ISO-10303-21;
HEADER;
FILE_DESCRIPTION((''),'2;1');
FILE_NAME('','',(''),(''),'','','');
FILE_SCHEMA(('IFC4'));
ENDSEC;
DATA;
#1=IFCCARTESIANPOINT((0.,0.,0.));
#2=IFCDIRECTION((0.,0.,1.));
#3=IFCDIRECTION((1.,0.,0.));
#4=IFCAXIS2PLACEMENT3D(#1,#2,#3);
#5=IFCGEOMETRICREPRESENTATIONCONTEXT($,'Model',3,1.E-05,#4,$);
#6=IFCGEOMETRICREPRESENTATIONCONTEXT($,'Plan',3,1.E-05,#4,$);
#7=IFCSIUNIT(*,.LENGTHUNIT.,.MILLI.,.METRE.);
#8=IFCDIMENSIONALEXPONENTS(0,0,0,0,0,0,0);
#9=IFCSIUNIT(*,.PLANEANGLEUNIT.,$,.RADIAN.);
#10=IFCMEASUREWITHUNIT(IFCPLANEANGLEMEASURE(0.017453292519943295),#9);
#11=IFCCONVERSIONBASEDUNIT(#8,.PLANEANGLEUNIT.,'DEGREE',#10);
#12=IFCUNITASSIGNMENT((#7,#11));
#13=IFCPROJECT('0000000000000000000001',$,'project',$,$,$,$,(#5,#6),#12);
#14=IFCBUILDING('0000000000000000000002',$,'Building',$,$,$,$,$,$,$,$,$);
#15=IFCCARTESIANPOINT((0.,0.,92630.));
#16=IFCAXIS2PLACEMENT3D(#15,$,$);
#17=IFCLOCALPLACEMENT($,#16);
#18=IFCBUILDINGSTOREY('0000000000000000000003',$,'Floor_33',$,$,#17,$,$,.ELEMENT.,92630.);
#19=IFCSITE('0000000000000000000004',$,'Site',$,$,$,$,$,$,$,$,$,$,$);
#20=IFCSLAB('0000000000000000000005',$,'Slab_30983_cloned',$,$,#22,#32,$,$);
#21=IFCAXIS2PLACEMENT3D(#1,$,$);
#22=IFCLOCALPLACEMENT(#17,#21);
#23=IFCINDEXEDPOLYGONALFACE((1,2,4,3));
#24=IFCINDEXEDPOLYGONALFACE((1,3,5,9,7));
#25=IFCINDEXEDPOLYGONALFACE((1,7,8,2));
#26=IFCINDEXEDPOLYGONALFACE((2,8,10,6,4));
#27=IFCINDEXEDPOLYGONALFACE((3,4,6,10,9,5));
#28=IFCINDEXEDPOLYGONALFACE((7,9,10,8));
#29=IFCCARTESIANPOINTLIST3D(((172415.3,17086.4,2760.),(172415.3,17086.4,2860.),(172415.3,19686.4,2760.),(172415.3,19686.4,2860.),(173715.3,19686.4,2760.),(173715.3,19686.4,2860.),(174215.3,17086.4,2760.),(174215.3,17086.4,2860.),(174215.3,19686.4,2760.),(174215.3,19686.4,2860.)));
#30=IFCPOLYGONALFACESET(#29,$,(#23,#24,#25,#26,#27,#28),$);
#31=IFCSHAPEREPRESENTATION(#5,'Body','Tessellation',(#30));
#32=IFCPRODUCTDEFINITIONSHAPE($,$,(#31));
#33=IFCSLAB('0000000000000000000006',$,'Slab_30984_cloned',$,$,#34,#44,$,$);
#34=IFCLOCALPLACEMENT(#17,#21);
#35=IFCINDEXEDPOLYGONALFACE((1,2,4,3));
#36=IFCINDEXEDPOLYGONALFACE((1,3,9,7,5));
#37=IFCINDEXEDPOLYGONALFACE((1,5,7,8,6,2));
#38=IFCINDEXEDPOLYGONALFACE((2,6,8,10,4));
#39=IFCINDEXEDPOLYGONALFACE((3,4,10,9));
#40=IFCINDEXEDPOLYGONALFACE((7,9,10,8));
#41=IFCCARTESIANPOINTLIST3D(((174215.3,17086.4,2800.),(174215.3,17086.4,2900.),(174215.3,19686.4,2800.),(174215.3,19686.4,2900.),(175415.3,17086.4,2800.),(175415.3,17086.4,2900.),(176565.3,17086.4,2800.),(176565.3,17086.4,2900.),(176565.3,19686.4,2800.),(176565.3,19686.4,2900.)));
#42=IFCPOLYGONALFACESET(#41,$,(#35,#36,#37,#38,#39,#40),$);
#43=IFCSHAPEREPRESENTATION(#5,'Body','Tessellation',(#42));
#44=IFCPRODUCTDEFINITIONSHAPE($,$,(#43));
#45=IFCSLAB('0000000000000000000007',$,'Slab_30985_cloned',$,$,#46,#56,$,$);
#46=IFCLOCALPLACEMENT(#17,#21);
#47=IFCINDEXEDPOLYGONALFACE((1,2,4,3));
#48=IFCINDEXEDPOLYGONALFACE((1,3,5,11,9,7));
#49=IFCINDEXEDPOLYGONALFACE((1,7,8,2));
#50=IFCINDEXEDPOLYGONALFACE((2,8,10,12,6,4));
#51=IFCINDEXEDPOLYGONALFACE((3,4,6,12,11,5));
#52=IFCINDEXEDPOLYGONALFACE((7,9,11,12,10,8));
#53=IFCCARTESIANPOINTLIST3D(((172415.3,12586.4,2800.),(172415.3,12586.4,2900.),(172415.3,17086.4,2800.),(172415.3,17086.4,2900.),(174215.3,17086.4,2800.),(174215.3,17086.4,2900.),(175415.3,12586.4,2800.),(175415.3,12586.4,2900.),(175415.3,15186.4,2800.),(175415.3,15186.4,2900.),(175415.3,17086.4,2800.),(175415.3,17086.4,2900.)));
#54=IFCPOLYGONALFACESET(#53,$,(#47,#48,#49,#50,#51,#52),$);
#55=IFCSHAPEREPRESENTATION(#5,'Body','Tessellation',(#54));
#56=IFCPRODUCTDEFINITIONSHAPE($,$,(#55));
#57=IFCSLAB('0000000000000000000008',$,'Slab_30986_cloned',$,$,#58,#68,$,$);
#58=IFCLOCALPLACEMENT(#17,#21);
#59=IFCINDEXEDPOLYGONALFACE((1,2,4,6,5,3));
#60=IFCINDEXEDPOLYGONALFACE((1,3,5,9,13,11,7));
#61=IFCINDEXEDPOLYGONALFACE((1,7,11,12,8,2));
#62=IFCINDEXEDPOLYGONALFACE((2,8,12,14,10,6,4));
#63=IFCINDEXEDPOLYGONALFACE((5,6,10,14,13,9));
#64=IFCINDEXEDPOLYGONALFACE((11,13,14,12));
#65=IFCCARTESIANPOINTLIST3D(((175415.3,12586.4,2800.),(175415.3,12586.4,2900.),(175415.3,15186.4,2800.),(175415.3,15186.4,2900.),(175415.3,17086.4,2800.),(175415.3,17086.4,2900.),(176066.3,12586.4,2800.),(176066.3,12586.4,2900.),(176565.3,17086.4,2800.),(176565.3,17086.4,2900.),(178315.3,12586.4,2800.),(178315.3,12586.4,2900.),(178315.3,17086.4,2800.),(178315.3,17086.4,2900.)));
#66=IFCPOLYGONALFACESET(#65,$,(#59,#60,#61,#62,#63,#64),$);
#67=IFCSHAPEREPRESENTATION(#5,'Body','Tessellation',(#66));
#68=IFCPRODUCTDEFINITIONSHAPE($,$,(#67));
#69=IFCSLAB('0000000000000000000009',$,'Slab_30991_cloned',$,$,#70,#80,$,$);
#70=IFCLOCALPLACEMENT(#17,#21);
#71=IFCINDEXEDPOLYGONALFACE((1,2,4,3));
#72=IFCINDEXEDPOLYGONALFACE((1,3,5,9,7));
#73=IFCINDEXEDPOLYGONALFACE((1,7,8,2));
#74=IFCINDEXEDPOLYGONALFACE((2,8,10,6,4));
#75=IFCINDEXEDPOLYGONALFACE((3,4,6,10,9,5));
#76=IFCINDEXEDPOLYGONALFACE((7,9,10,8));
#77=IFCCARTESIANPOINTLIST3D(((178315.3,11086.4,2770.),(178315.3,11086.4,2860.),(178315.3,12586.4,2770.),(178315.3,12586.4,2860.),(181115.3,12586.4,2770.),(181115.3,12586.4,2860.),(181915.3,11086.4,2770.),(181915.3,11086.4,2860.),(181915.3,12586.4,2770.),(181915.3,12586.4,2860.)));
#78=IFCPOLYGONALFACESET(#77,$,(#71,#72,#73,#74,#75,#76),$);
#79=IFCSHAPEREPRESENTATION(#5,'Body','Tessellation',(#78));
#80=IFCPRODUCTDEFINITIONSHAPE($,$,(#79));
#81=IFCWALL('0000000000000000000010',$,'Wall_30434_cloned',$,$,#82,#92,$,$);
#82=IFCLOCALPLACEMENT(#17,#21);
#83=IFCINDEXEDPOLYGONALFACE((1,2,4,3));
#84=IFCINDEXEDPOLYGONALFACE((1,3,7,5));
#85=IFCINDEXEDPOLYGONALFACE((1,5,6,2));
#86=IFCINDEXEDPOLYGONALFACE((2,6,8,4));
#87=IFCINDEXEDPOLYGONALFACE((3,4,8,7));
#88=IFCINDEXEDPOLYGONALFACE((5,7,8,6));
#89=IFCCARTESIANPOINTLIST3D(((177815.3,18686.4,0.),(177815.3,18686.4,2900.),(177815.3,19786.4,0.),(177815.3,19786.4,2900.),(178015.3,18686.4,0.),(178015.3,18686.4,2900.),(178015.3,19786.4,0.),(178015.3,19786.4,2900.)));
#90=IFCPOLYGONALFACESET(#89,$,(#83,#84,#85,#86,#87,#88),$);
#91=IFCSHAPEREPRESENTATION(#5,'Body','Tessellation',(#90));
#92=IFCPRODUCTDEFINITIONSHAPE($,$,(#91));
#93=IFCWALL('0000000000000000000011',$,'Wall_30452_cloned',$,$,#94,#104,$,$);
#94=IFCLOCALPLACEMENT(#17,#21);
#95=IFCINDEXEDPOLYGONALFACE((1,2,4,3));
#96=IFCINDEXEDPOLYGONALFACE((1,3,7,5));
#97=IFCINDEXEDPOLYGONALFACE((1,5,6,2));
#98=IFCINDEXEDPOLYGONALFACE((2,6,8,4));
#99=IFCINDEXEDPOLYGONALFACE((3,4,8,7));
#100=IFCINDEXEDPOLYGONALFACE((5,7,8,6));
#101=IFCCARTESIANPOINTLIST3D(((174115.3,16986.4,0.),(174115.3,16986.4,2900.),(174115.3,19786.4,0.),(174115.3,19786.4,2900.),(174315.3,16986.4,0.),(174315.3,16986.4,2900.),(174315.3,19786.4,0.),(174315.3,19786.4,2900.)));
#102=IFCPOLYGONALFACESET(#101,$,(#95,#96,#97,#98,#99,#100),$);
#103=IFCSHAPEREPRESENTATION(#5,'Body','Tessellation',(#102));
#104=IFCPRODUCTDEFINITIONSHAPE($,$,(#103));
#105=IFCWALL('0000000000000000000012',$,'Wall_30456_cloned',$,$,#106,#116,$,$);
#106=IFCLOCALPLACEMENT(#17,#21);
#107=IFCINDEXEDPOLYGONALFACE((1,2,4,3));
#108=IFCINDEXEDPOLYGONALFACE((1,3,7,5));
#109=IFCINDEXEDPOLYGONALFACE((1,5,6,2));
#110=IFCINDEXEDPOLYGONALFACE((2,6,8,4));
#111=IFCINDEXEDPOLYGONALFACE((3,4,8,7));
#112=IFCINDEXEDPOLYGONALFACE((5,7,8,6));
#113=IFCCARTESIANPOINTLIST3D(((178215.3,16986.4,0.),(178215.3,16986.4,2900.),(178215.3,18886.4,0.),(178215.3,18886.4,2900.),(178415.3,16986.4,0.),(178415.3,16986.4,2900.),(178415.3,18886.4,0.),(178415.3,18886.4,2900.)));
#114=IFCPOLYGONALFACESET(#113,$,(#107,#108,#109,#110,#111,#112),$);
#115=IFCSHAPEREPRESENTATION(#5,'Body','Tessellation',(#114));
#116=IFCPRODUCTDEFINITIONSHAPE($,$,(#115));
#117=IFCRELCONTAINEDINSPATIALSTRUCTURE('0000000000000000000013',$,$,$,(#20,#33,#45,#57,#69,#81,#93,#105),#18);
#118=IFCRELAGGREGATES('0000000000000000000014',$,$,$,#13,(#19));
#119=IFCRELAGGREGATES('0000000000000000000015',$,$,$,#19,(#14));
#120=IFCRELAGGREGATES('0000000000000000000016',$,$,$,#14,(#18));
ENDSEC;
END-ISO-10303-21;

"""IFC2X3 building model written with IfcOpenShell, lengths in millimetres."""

from ifc_helpers import new_model, entity, si_unit, converted_unit, frame, origin_with_axes, origin_2d, place, context, project, spatial, polyline, rectangle, outline, extrude, source, transform, mapped, element, save


model = new_model("IFC2X3")

# Units and contexts
model_context = context("Model", 3, precision=1e-05, world=origin_with_axes())
plan_context = context("Plan", 3, precision=1e-05, world=origin_with_axes())
ifc_project = project(units=[si_unit("LENGTHUNIT", "METRE", prefix="MILLI"), converted_unit("PLANEANGLEUNIT", "DEGREE", entity("IfcPlaneAngleMeasure", 0.017453292519943295), si_unit("PLANEANGLEUNIT", "RADIAN"), dimensions=[0, 0, 0, 0, 0, 0, 0])], contexts=[model_context, plan_context])

# Site, building, storey
site = spatial("IfcSite", under=ifc_project, Name="Site")
building = spatial("IfcBuilding", under=site, Name="Building")
storey_placement = place(None, frame((0.0, 0.0, 92630.0)))
storey = spatial("IfcBuildingStorey", under=building, at=storey_placement, Name="Floor_33", CompositionType="ELEMENT", Elevation=92630.0)

# Slabs
shared_shape_1 = source(origin_with_axes(), model_context, "Body", "SweptSolid", [
    extrude(outline(polyline([(0.0, 0.0), (2600.0, 0.0), (2600.0, 1800.0), (0.0, 1800.0), (0.0, 1300.0)])), origin_with_axes(), (0.0, 0.0, 1.0), 100.0),
])
slab_1_placement = place(storey_placement, frame((172415.3, 19686.4, 2760.0), z_axis=(0.0, 0.0, 1.0), x_axis=(0.0, -2599.99, 0.0)))
element("IfcSlab", 1, at=slab_1_placement, inside=storey, Name="Slab_30983_cloned", context=model_context, shape_type="MappedRepresentation", body=[
    mapped(shared_shape_1, transform((0.0, 0.0, 0.0), x_axis=(1.0, 0.0, 0.0), y_axis=(0.0, 1.0, 0.0), z_axis=(0.0, 0.0, 1.0), scale=1.0)),
])
shared_shape_2 = source(origin_with_axes(), model_context, "Body", "SweptSolid", [
    extrude(outline(polyline([(0.0, 0.0), (2600.0, 0.0), (2600.0, 1200.0), (2600.0, 2350.0), (0.0, 2350.0)])), origin_with_axes(), (0.0, 0.0, 1.0), 100.0),
])
slab_2_placement = place(storey_placement, frame((174215.3, 19686.4, 2800.0), z_axis=(0.0, 0.0, 1.0), x_axis=(0.0, -2599.99, 0.0)))
element("IfcSlab", 2, at=slab_2_placement, inside=storey, Name="Slab_30984_cloned", context=model_context, shape_type="MappedRepresentation", body=[
    mapped(shared_shape_2, transform((0.0, 0.0, 0.0), x_axis=(1.0, 0.0, 0.0), y_axis=(0.0, 1.0, 0.0), z_axis=(0.0, 0.0, 1.0), scale=1.0)),
])
shared_shape_3 = source(origin_with_axes(), model_context, "Body", "SweptSolid", [
    extrude(outline(polyline([(0.0, 0.0), (4500.0, 0.0), (4500.0, 3000.0), (1900.0, 3000.0), (0.0, 3000.0), (0.0, 1800.0)])), origin_with_axes(), (0.0, 0.0, 1.0), 100.0),
])
slab_3_placement = place(storey_placement, frame((172415.3, 17086.4, 2800.0), z_axis=(0.0, 0.0, 1.0), x_axis=(0.0, -4500.031, 0.0)))
element("IfcSlab", 3, at=slab_3_placement, inside=storey, Name="Slab_30985_cloned", context=model_context, shape_type="MappedRepresentation", body=[
    mapped(shared_shape_3, transform((0.0, 0.0, 0.0), x_axis=(1.0, 0.0, 0.0), y_axis=(0.0, 1.0, 0.0), z_axis=(0.0, 0.0, 1.0), scale=1.0)),
])
shared_shape_4 = source(origin_with_axes(), model_context, "Body", "SweptSolid", [
    extrude(outline(polyline([(0.0, 0.0), (1900.0, 0.0), (4500.0, 0.0), (4500.0, 651.0), (4500.0, 2900.0), (0.0, 2900.0), (0.0, 1150.0)])), origin_with_axes(), (0.0, 0.0, 1.0), 100.0),
])
slab_4_placement = place(storey_placement, frame((175415.3, 17086.4, 2800.0), z_axis=(0.0, 0.0, 1.0), x_axis=(-0.006, -1900.025, 0.0)))
element("IfcSlab", 4, at=slab_4_placement, inside=storey, Name="Slab_30986_cloned", context=model_context, shape_type="MappedRepresentation", body=[
    mapped(shared_shape_4, transform((0.0, 0.0, 0.0), x_axis=(1.0, 0.0, 0.0), y_axis=(0.0, 1.0, 0.0), z_axis=(0.0, 0.0, 1.0), scale=1.0)),
])
shared_shape_5 = source(origin_with_axes(), model_context, "Body", "SweptSolid", [
    extrude(outline(polyline([(0.0, 0.0), (1500.0, 0.0), (1500.0, 3600.0), (0.0, 3600.0), (0.0, 2800.0)])), origin_with_axes(), (0.0, 0.0, 1.0), 90.0),
])
slab_5_placement = place(storey_placement, frame((178315.3, 12586.4, 2770.0), z_axis=(0.0, 0.0, 1.0), x_axis=(0.0, -1500.0, 0.0)))
element("IfcSlab", 5, at=slab_5_placement, inside=storey, Name="Slab_30991_cloned", context=model_context, shape_type="MappedRepresentation", body=[
    mapped(shared_shape_5, transform((0.0, 0.0, 0.0), x_axis=(1.0, 0.0, 0.0), y_axis=(0.0, 1.0, 0.0), z_axis=(0.0, 0.0, 1.0), scale=1.0)),
])

# Walls
shared_shape_6 = source(origin_with_axes(), model_context, "Body", "SweptSolid", [
    extrude(rectangle(XDim=1100.0, YDim=200.0, at=origin_2d()), origin_with_axes(), (0.0, 0.0, 1.0), 2900.0),
])
wall_1_placement = place(storey_placement, frame((177915.3, 19236.4, 0.0), z_axis=(0.0, 0.0, 1.0), x_axis=(0.000094, 1099.995689, 0.0)))
element("IfcWall", 6, at=wall_1_placement, inside=storey, Name="Wall_30434_cloned", context=model_context, shape_type="MappedRepresentation", body=[
    mapped(shared_shape_6, transform((0.0, 0.0, 0.0), x_axis=(1.0, 0.0, 0.0), y_axis=(0.0, 1.0, 0.0), z_axis=(0.0, 0.0, 1.0), scale=1.0)),
])
shared_shape_7 = source(origin_with_axes(), model_context, "Body", "SweptSolid", [
    extrude(rectangle(XDim=2800.0, YDim=200.0, at=origin_2d()), origin_with_axes(), (0.0, 0.0, 1.0), 2900.0),
])
wall_2_placement = place(storey_placement, frame((174215.3, 18386.4, 0.0), z_axis=(0.0, 0.0, 1.0), x_axis=(0.0, 2799.990212, 0.0)))
element("IfcWall", 7, at=wall_2_placement, inside=storey, Name="Wall_30452_cloned", context=model_context, shape_type="MappedRepresentation", body=[
    mapped(shared_shape_7, transform((0.0, 0.0, 0.0), x_axis=(1.0, 0.0, 0.0), y_axis=(0.0, 1.0, 0.0), z_axis=(0.0, 0.0, 1.0), scale=1.0)),
])
shared_shape_8 = source(origin_with_axes(), model_context, "Body", "SweptSolid", [
    extrude(rectangle(XDim=1900.0, YDim=200.0, at=origin_2d()), origin_with_axes(), (0.0, 0.0, 1.0), 2900.0),
])
wall_3_placement = place(storey_placement, frame((178315.3, 17936.4, 0.0), z_axis=(0.0, 0.0, 1.0), x_axis=(0.000403, 1899.988898, 0.0)))
element("IfcWall", 8, at=wall_3_placement, inside=storey, Name="Wall_30456_cloned", context=model_context, shape_type="MappedRepresentation", body=[
    mapped(shared_shape_8, transform((0.0, 0.0, 0.0), x_axis=(1.0, 0.0, 0.0), y_axis=(0.0, 1.0, 0.0), z_axis=(0.0, 0.0, 1.0), scale=1.0)),
])

save(model, "model.ifc")
